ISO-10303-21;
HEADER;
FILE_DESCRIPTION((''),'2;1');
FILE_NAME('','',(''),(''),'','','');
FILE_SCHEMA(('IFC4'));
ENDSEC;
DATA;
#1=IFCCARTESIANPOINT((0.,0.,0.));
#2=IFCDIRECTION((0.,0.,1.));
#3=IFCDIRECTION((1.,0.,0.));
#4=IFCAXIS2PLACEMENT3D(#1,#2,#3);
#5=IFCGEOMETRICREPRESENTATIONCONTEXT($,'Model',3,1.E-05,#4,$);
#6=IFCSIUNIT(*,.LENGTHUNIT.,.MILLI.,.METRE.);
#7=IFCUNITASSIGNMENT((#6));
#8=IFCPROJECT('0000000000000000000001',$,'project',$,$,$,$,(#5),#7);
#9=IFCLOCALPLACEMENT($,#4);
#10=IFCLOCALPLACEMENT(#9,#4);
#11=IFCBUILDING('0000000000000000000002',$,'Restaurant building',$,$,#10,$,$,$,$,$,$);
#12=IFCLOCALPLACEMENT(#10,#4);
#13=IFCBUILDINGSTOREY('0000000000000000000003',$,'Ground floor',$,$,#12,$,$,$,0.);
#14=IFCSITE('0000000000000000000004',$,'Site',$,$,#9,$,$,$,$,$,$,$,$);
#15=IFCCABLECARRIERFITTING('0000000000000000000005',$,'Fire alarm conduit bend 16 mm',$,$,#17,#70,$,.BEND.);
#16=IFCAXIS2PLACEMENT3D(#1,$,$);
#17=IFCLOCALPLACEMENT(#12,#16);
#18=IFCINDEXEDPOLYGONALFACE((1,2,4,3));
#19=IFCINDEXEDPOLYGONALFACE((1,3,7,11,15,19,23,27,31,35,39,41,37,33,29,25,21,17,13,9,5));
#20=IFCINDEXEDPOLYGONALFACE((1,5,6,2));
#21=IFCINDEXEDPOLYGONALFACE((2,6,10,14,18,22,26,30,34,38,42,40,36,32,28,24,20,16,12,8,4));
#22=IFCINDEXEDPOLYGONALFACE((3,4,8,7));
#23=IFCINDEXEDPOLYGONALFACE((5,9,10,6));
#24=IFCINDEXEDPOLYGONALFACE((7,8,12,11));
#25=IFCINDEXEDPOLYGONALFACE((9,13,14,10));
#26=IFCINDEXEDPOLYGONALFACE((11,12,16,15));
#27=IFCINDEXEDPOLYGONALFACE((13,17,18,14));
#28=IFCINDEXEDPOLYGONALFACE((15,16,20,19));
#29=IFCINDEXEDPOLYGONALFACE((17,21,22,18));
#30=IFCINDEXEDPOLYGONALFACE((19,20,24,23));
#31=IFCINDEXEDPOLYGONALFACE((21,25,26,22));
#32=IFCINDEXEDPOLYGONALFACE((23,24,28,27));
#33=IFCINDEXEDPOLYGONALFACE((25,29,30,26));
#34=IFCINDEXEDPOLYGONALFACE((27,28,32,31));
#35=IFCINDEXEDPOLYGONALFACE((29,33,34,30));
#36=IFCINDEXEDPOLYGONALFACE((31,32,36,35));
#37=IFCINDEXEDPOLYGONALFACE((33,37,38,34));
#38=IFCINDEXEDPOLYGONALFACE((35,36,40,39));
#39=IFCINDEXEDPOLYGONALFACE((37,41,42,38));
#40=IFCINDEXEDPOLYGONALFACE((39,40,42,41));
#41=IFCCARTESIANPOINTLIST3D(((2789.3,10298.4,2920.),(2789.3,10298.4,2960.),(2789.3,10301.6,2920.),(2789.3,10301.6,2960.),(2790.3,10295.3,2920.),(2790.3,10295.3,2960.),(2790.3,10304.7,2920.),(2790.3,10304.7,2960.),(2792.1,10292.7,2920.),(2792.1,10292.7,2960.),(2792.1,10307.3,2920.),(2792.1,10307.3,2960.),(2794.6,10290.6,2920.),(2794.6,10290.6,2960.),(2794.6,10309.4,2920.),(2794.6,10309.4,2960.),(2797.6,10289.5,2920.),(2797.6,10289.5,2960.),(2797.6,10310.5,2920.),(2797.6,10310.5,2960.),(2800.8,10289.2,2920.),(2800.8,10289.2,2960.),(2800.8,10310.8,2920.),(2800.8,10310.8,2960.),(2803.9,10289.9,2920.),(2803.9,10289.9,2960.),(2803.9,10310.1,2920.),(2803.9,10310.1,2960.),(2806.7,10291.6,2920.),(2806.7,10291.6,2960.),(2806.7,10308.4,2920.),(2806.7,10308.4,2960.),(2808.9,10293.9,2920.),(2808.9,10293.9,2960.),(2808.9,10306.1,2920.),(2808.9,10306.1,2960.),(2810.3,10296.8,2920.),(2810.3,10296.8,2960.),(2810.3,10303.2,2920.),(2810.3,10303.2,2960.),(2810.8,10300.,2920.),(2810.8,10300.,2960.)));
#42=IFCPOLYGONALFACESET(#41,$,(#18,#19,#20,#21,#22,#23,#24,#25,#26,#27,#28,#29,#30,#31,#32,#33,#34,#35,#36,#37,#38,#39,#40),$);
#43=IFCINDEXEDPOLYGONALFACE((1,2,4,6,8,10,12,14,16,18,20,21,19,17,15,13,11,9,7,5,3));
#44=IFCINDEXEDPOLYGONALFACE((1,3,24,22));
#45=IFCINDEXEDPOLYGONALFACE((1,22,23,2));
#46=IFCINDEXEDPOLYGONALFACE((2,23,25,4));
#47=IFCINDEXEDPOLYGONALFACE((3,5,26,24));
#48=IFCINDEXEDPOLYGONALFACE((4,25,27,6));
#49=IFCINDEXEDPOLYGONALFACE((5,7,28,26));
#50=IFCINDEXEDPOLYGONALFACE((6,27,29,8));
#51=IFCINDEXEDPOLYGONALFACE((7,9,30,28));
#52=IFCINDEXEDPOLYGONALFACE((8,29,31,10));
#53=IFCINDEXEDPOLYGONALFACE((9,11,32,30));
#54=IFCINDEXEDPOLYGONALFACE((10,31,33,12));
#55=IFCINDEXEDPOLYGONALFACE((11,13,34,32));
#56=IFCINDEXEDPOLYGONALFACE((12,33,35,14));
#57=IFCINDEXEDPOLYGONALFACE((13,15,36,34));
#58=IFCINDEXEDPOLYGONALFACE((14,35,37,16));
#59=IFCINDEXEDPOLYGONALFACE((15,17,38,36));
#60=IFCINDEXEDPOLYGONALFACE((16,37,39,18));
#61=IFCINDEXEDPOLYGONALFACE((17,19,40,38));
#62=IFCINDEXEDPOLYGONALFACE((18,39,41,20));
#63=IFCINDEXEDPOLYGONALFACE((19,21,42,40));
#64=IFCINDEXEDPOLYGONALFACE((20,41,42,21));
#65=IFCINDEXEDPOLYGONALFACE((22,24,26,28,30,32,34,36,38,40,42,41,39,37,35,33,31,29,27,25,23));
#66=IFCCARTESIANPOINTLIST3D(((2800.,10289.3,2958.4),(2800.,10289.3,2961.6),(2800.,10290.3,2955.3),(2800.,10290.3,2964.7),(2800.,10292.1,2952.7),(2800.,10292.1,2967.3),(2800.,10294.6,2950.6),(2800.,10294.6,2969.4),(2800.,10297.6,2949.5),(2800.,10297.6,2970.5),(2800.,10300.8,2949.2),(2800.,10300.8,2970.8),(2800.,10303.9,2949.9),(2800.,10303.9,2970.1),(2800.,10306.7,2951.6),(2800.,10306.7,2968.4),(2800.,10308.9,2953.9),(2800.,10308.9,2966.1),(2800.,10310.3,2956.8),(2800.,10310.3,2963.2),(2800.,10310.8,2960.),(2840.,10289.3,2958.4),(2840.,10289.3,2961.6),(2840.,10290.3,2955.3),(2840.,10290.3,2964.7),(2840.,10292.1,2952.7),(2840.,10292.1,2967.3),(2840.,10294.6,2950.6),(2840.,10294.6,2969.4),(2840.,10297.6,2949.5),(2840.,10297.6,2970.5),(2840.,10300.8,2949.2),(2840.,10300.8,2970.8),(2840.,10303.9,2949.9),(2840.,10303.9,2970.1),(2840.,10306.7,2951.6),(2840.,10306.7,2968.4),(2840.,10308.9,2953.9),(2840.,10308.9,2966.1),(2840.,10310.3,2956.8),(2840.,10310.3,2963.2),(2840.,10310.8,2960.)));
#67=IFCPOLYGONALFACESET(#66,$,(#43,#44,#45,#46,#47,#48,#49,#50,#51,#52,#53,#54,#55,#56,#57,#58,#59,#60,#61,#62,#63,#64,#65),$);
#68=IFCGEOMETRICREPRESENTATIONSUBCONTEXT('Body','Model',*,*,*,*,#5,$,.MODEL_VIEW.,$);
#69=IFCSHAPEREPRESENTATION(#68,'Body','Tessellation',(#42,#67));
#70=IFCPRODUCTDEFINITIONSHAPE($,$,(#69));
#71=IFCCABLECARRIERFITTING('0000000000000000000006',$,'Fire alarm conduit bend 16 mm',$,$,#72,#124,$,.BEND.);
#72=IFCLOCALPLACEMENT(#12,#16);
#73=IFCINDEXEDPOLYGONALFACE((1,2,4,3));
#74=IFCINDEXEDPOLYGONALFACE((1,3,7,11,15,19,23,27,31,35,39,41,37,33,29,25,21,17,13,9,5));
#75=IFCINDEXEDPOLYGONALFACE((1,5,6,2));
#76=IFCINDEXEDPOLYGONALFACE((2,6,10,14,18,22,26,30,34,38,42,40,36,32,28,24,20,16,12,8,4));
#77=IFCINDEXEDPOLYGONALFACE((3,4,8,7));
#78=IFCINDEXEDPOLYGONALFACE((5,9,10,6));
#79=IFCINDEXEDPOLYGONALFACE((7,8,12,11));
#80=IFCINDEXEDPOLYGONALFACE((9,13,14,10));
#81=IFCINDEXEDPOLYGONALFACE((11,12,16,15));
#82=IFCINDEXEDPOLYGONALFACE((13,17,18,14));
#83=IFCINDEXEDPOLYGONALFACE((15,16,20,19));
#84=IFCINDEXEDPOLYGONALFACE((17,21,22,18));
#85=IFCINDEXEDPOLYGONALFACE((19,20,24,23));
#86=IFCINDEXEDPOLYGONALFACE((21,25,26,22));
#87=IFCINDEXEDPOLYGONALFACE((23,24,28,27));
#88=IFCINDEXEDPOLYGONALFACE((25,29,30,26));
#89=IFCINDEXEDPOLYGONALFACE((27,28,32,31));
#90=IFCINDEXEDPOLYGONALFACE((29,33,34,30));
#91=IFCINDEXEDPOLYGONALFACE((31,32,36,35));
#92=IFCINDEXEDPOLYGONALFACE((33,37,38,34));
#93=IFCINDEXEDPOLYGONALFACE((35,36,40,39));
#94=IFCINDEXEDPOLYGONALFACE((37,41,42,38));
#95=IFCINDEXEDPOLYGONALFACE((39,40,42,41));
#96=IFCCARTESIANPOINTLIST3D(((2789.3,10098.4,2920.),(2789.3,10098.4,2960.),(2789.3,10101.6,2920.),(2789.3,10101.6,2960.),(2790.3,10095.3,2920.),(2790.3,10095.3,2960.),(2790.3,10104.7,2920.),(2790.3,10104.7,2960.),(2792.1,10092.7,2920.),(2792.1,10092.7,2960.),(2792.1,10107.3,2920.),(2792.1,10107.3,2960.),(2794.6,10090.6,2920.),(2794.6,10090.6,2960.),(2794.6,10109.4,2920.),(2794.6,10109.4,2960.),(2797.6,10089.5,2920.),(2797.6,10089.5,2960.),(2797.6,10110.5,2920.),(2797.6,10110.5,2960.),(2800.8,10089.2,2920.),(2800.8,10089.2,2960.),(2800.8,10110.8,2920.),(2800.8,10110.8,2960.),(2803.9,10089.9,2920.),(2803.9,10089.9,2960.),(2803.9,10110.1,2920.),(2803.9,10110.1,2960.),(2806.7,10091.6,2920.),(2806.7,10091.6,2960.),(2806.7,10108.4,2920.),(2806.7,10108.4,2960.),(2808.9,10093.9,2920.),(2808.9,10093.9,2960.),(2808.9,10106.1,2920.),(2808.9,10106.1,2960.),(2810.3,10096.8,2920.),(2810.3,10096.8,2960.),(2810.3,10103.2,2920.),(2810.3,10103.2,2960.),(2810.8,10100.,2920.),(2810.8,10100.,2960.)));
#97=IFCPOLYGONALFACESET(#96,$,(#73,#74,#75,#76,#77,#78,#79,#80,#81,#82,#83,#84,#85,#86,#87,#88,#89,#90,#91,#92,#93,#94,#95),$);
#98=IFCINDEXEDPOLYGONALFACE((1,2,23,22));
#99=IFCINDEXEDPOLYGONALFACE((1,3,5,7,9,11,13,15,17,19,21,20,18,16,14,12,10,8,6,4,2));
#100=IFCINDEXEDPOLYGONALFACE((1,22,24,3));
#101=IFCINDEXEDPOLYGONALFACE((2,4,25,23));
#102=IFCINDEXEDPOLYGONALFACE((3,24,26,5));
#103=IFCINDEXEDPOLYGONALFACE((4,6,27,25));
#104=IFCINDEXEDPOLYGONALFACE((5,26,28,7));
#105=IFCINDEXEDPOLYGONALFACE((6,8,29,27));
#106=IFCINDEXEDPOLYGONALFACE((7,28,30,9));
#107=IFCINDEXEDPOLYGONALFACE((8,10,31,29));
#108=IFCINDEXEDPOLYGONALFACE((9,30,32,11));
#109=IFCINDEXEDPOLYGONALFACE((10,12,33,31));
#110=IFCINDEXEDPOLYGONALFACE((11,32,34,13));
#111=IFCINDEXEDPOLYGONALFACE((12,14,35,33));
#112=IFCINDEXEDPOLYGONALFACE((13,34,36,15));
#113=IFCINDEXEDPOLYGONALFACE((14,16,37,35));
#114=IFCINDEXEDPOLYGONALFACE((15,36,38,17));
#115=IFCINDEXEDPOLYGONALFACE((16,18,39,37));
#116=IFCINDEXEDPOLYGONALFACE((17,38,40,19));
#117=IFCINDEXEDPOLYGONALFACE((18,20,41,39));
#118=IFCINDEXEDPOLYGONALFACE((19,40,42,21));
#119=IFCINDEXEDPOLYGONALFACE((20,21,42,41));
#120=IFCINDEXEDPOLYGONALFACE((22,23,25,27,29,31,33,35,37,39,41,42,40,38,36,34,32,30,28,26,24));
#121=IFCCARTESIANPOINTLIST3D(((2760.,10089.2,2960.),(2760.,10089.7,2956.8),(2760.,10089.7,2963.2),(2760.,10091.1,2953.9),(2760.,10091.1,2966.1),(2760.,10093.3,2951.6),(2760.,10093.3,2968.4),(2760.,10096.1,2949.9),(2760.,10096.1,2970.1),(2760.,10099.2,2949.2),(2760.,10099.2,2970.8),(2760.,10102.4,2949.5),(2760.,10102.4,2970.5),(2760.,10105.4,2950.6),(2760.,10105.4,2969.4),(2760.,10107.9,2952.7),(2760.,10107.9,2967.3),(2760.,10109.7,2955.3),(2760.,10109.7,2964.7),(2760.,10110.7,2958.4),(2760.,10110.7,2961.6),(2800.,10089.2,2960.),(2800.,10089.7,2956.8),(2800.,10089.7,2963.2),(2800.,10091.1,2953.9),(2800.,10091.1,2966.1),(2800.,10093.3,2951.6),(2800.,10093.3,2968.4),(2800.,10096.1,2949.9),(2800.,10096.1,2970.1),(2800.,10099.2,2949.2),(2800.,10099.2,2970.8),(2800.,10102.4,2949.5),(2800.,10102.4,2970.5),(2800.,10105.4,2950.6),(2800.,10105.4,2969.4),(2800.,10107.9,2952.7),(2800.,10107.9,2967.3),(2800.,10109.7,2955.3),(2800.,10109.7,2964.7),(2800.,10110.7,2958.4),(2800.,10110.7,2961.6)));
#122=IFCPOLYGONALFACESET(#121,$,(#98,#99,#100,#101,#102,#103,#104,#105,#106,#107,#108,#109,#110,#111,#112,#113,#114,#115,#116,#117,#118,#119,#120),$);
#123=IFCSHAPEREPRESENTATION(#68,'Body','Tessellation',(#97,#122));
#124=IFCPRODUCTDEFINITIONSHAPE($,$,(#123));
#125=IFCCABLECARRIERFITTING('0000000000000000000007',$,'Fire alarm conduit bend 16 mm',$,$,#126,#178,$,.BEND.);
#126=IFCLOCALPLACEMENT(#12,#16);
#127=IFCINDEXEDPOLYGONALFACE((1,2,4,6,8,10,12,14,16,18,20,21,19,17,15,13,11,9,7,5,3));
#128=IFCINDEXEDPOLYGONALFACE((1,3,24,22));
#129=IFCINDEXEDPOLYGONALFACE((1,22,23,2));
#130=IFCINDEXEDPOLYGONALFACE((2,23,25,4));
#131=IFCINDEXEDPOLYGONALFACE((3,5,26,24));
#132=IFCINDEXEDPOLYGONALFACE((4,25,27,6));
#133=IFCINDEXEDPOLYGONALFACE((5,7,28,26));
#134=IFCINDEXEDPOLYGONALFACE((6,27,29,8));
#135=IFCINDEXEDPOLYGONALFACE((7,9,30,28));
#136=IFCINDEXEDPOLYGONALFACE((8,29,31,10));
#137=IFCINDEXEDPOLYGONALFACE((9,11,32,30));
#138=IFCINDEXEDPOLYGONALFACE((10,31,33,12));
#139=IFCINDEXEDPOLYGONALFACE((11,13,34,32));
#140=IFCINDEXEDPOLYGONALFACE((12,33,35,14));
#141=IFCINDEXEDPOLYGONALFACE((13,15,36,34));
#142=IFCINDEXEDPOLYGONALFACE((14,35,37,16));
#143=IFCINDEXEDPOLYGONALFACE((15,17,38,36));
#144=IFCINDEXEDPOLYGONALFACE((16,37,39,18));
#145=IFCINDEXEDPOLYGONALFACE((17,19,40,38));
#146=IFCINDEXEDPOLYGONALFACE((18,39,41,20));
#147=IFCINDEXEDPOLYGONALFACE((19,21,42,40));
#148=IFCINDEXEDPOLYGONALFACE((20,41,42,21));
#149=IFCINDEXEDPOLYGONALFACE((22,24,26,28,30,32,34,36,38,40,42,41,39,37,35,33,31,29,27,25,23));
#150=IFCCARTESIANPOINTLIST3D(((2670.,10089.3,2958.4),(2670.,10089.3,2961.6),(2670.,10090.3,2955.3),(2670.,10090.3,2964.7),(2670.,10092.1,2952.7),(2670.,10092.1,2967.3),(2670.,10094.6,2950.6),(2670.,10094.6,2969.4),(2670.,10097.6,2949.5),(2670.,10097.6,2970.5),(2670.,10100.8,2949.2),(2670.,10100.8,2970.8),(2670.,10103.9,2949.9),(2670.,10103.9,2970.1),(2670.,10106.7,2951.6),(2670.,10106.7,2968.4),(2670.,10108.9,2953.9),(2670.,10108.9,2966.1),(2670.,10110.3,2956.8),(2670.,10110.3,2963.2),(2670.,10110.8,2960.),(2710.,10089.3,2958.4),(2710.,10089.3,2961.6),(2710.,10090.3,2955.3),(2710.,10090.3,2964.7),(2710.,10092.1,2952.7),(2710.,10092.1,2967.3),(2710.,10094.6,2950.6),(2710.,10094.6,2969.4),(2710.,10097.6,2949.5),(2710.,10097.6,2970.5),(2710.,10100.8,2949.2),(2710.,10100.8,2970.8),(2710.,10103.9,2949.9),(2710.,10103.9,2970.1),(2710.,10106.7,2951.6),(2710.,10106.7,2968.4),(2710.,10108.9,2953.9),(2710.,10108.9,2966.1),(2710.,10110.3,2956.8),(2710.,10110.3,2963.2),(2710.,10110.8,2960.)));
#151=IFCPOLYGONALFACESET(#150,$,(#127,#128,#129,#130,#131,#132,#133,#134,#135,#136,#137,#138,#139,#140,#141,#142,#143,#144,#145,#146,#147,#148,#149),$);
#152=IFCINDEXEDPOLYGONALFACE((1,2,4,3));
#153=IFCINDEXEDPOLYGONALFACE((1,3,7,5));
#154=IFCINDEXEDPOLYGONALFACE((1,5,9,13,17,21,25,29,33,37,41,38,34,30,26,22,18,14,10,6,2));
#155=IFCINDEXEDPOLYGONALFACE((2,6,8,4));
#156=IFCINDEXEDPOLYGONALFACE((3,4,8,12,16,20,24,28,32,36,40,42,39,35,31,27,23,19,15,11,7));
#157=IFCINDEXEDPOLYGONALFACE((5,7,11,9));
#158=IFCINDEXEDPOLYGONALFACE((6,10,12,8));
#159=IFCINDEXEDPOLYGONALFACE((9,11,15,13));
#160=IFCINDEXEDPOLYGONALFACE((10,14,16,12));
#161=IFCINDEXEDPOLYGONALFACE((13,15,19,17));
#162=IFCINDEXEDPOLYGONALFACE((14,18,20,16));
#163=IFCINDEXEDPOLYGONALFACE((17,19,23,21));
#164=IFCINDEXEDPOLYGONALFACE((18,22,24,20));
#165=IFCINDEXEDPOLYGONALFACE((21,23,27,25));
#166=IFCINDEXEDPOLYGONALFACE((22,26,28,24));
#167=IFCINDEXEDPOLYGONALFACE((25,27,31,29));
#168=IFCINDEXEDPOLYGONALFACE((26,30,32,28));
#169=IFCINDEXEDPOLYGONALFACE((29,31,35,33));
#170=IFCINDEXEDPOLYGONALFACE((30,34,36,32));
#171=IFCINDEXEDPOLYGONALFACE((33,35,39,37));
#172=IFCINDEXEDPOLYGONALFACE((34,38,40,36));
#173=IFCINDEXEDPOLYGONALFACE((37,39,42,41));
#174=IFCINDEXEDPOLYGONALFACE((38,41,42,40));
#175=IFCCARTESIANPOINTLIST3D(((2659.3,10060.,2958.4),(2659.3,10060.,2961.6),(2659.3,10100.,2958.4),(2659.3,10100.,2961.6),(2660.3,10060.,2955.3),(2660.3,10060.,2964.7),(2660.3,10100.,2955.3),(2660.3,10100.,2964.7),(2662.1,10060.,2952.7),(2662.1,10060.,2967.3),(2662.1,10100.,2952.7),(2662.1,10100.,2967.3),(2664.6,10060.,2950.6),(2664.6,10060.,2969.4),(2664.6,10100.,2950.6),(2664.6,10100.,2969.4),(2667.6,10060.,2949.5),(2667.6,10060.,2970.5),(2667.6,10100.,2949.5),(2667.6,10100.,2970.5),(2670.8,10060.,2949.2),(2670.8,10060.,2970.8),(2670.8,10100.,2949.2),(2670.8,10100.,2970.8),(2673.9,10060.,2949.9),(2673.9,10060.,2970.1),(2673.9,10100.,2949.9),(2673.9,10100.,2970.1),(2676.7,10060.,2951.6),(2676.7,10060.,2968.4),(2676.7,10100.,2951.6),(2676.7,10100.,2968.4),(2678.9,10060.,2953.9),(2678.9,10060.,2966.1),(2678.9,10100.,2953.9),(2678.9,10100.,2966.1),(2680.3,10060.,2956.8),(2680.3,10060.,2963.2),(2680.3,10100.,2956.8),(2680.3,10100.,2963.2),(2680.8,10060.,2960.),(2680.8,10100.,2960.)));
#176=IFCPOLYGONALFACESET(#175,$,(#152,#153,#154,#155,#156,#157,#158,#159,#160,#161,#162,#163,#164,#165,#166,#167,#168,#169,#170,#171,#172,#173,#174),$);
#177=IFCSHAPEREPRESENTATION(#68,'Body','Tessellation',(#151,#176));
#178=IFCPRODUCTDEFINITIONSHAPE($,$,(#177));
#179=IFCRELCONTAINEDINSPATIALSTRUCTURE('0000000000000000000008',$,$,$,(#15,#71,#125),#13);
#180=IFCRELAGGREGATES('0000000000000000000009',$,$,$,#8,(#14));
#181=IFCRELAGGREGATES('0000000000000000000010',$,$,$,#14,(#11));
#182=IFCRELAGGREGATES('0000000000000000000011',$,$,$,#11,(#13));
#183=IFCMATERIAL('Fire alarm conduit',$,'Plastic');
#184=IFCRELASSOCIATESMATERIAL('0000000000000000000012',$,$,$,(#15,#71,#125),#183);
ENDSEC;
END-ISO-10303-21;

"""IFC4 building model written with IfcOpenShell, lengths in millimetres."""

from ifc_helpers import new_model, si_unit, frame, origin_with_axes, origin_2d, place, context, subcontext, project, spatial, circle, extrude, material, element, save


model = new_model("IFC4")

# Units and contexts
model_context = context("Model", 3, precision=1e-05, world=origin_with_axes())
body_context = subcontext(model_context, "Body", "Model", "MODEL_VIEW")
ifc_project = project(units=[si_unit("LENGTHUNIT", "METRE", prefix="MILLI")], contexts=[model_context])

# Site, building, storey
site_placement = place(None, origin_with_axes())
site = spatial("IfcSite", under=ifc_project, at=site_placement, Name="Site")
building_placement = place(site_placement, origin_with_axes())
building = spatial("IfcBuilding", under=site, at=building_placement, Name="Restaurant building")
storey_placement = place(building_placement, origin_with_axes())
storey = spatial("IfcBuildingStorey", under=building, at=storey_placement, Name="Ground floor", Elevation=0.0)

# Shared definitions
ifc_material_1 = material(Name="Fire alarm conduit", Category="Plastic")

# Cable carrier fittings
cable_carrier_fitting_1_placement = place(storey_placement, frame((2800.0, 10300.0, 2960.0)))
element("IfcCableCarrierFitting", 1, at=cable_carrier_fitting_1_placement, inside=storey, material=ifc_material_1, Name="Fire alarm conduit bend 16 mm", PredefinedType="BEND", context=body_context, shape_type="SweptSolid", body=[
    extrude(circle(Radius=10.8, at=origin_2d()), frame((0.0, 0.0, 0.0), z_axis=(0.0, 0.0, -1.0), x_axis=(1.0, 0.0, 0.0)), (0.0, 0.0, 1.0), 40.0),
    extrude(circle(Radius=10.8, at=origin_2d()), frame((0.0, 0.0, 0.0), z_axis=(1.0, 0.0, 0.0), x_axis=(0.0, 1.0, 0.0)), (0.0, 0.0, 1.0), 40.0),
])
cable_carrier_fitting_2_placement = place(storey_placement, frame((2800.0, 10100.0, 2960.0)))
element("IfcCableCarrierFitting", 2, at=cable_carrier_fitting_2_placement, inside=storey, material=ifc_material_1, Name="Fire alarm conduit bend 16 mm", PredefinedType="BEND", context=body_context, shape_type="SweptSolid", body=[
    extrude(circle(Radius=10.8, at=origin_2d()), frame((0.0, 0.0, 0.0), z_axis=(0.0, 0.0, -1.0), x_axis=(1.0, 0.0, 0.0)), (0.0, 0.0, 1.0), 40.0),
    extrude(circle(Radius=10.8, at=origin_2d()), frame((0.0, 0.0, 0.0), z_axis=(-1.0, 0.0, 0.0), x_axis=(0.0, -1.0, 0.0)), (0.0, 0.0, 1.0), 40.0),
])
cable_carrier_fitting_3_placement = place(storey_placement, frame((2670.0, 10100.0, 2960.0)))
element("IfcCableCarrierFitting", 3, at=cable_carrier_fitting_3_placement, inside=storey, material=ifc_material_1, Name="Fire alarm conduit bend 16 mm", PredefinedType="BEND", context=body_context, shape_type="SweptSolid", body=[
    extrude(circle(Radius=10.8, at=origin_2d()), frame((0.0, 0.0, 0.0), z_axis=(1.0, 0.0, 0.0), x_axis=(0.0, 1.0, 0.0)), (0.0, 0.0, 1.0), 40.0),
    extrude(circle(Radius=10.8, at=origin_2d()), frame((0.0, 0.0, 0.0), z_axis=(0.0, -1.0, 0.0), x_axis=(1.0, 0.0, 0.0)), (0.0, 0.0, 1.0), 40.0),
])

save(model, "model.ifc")
